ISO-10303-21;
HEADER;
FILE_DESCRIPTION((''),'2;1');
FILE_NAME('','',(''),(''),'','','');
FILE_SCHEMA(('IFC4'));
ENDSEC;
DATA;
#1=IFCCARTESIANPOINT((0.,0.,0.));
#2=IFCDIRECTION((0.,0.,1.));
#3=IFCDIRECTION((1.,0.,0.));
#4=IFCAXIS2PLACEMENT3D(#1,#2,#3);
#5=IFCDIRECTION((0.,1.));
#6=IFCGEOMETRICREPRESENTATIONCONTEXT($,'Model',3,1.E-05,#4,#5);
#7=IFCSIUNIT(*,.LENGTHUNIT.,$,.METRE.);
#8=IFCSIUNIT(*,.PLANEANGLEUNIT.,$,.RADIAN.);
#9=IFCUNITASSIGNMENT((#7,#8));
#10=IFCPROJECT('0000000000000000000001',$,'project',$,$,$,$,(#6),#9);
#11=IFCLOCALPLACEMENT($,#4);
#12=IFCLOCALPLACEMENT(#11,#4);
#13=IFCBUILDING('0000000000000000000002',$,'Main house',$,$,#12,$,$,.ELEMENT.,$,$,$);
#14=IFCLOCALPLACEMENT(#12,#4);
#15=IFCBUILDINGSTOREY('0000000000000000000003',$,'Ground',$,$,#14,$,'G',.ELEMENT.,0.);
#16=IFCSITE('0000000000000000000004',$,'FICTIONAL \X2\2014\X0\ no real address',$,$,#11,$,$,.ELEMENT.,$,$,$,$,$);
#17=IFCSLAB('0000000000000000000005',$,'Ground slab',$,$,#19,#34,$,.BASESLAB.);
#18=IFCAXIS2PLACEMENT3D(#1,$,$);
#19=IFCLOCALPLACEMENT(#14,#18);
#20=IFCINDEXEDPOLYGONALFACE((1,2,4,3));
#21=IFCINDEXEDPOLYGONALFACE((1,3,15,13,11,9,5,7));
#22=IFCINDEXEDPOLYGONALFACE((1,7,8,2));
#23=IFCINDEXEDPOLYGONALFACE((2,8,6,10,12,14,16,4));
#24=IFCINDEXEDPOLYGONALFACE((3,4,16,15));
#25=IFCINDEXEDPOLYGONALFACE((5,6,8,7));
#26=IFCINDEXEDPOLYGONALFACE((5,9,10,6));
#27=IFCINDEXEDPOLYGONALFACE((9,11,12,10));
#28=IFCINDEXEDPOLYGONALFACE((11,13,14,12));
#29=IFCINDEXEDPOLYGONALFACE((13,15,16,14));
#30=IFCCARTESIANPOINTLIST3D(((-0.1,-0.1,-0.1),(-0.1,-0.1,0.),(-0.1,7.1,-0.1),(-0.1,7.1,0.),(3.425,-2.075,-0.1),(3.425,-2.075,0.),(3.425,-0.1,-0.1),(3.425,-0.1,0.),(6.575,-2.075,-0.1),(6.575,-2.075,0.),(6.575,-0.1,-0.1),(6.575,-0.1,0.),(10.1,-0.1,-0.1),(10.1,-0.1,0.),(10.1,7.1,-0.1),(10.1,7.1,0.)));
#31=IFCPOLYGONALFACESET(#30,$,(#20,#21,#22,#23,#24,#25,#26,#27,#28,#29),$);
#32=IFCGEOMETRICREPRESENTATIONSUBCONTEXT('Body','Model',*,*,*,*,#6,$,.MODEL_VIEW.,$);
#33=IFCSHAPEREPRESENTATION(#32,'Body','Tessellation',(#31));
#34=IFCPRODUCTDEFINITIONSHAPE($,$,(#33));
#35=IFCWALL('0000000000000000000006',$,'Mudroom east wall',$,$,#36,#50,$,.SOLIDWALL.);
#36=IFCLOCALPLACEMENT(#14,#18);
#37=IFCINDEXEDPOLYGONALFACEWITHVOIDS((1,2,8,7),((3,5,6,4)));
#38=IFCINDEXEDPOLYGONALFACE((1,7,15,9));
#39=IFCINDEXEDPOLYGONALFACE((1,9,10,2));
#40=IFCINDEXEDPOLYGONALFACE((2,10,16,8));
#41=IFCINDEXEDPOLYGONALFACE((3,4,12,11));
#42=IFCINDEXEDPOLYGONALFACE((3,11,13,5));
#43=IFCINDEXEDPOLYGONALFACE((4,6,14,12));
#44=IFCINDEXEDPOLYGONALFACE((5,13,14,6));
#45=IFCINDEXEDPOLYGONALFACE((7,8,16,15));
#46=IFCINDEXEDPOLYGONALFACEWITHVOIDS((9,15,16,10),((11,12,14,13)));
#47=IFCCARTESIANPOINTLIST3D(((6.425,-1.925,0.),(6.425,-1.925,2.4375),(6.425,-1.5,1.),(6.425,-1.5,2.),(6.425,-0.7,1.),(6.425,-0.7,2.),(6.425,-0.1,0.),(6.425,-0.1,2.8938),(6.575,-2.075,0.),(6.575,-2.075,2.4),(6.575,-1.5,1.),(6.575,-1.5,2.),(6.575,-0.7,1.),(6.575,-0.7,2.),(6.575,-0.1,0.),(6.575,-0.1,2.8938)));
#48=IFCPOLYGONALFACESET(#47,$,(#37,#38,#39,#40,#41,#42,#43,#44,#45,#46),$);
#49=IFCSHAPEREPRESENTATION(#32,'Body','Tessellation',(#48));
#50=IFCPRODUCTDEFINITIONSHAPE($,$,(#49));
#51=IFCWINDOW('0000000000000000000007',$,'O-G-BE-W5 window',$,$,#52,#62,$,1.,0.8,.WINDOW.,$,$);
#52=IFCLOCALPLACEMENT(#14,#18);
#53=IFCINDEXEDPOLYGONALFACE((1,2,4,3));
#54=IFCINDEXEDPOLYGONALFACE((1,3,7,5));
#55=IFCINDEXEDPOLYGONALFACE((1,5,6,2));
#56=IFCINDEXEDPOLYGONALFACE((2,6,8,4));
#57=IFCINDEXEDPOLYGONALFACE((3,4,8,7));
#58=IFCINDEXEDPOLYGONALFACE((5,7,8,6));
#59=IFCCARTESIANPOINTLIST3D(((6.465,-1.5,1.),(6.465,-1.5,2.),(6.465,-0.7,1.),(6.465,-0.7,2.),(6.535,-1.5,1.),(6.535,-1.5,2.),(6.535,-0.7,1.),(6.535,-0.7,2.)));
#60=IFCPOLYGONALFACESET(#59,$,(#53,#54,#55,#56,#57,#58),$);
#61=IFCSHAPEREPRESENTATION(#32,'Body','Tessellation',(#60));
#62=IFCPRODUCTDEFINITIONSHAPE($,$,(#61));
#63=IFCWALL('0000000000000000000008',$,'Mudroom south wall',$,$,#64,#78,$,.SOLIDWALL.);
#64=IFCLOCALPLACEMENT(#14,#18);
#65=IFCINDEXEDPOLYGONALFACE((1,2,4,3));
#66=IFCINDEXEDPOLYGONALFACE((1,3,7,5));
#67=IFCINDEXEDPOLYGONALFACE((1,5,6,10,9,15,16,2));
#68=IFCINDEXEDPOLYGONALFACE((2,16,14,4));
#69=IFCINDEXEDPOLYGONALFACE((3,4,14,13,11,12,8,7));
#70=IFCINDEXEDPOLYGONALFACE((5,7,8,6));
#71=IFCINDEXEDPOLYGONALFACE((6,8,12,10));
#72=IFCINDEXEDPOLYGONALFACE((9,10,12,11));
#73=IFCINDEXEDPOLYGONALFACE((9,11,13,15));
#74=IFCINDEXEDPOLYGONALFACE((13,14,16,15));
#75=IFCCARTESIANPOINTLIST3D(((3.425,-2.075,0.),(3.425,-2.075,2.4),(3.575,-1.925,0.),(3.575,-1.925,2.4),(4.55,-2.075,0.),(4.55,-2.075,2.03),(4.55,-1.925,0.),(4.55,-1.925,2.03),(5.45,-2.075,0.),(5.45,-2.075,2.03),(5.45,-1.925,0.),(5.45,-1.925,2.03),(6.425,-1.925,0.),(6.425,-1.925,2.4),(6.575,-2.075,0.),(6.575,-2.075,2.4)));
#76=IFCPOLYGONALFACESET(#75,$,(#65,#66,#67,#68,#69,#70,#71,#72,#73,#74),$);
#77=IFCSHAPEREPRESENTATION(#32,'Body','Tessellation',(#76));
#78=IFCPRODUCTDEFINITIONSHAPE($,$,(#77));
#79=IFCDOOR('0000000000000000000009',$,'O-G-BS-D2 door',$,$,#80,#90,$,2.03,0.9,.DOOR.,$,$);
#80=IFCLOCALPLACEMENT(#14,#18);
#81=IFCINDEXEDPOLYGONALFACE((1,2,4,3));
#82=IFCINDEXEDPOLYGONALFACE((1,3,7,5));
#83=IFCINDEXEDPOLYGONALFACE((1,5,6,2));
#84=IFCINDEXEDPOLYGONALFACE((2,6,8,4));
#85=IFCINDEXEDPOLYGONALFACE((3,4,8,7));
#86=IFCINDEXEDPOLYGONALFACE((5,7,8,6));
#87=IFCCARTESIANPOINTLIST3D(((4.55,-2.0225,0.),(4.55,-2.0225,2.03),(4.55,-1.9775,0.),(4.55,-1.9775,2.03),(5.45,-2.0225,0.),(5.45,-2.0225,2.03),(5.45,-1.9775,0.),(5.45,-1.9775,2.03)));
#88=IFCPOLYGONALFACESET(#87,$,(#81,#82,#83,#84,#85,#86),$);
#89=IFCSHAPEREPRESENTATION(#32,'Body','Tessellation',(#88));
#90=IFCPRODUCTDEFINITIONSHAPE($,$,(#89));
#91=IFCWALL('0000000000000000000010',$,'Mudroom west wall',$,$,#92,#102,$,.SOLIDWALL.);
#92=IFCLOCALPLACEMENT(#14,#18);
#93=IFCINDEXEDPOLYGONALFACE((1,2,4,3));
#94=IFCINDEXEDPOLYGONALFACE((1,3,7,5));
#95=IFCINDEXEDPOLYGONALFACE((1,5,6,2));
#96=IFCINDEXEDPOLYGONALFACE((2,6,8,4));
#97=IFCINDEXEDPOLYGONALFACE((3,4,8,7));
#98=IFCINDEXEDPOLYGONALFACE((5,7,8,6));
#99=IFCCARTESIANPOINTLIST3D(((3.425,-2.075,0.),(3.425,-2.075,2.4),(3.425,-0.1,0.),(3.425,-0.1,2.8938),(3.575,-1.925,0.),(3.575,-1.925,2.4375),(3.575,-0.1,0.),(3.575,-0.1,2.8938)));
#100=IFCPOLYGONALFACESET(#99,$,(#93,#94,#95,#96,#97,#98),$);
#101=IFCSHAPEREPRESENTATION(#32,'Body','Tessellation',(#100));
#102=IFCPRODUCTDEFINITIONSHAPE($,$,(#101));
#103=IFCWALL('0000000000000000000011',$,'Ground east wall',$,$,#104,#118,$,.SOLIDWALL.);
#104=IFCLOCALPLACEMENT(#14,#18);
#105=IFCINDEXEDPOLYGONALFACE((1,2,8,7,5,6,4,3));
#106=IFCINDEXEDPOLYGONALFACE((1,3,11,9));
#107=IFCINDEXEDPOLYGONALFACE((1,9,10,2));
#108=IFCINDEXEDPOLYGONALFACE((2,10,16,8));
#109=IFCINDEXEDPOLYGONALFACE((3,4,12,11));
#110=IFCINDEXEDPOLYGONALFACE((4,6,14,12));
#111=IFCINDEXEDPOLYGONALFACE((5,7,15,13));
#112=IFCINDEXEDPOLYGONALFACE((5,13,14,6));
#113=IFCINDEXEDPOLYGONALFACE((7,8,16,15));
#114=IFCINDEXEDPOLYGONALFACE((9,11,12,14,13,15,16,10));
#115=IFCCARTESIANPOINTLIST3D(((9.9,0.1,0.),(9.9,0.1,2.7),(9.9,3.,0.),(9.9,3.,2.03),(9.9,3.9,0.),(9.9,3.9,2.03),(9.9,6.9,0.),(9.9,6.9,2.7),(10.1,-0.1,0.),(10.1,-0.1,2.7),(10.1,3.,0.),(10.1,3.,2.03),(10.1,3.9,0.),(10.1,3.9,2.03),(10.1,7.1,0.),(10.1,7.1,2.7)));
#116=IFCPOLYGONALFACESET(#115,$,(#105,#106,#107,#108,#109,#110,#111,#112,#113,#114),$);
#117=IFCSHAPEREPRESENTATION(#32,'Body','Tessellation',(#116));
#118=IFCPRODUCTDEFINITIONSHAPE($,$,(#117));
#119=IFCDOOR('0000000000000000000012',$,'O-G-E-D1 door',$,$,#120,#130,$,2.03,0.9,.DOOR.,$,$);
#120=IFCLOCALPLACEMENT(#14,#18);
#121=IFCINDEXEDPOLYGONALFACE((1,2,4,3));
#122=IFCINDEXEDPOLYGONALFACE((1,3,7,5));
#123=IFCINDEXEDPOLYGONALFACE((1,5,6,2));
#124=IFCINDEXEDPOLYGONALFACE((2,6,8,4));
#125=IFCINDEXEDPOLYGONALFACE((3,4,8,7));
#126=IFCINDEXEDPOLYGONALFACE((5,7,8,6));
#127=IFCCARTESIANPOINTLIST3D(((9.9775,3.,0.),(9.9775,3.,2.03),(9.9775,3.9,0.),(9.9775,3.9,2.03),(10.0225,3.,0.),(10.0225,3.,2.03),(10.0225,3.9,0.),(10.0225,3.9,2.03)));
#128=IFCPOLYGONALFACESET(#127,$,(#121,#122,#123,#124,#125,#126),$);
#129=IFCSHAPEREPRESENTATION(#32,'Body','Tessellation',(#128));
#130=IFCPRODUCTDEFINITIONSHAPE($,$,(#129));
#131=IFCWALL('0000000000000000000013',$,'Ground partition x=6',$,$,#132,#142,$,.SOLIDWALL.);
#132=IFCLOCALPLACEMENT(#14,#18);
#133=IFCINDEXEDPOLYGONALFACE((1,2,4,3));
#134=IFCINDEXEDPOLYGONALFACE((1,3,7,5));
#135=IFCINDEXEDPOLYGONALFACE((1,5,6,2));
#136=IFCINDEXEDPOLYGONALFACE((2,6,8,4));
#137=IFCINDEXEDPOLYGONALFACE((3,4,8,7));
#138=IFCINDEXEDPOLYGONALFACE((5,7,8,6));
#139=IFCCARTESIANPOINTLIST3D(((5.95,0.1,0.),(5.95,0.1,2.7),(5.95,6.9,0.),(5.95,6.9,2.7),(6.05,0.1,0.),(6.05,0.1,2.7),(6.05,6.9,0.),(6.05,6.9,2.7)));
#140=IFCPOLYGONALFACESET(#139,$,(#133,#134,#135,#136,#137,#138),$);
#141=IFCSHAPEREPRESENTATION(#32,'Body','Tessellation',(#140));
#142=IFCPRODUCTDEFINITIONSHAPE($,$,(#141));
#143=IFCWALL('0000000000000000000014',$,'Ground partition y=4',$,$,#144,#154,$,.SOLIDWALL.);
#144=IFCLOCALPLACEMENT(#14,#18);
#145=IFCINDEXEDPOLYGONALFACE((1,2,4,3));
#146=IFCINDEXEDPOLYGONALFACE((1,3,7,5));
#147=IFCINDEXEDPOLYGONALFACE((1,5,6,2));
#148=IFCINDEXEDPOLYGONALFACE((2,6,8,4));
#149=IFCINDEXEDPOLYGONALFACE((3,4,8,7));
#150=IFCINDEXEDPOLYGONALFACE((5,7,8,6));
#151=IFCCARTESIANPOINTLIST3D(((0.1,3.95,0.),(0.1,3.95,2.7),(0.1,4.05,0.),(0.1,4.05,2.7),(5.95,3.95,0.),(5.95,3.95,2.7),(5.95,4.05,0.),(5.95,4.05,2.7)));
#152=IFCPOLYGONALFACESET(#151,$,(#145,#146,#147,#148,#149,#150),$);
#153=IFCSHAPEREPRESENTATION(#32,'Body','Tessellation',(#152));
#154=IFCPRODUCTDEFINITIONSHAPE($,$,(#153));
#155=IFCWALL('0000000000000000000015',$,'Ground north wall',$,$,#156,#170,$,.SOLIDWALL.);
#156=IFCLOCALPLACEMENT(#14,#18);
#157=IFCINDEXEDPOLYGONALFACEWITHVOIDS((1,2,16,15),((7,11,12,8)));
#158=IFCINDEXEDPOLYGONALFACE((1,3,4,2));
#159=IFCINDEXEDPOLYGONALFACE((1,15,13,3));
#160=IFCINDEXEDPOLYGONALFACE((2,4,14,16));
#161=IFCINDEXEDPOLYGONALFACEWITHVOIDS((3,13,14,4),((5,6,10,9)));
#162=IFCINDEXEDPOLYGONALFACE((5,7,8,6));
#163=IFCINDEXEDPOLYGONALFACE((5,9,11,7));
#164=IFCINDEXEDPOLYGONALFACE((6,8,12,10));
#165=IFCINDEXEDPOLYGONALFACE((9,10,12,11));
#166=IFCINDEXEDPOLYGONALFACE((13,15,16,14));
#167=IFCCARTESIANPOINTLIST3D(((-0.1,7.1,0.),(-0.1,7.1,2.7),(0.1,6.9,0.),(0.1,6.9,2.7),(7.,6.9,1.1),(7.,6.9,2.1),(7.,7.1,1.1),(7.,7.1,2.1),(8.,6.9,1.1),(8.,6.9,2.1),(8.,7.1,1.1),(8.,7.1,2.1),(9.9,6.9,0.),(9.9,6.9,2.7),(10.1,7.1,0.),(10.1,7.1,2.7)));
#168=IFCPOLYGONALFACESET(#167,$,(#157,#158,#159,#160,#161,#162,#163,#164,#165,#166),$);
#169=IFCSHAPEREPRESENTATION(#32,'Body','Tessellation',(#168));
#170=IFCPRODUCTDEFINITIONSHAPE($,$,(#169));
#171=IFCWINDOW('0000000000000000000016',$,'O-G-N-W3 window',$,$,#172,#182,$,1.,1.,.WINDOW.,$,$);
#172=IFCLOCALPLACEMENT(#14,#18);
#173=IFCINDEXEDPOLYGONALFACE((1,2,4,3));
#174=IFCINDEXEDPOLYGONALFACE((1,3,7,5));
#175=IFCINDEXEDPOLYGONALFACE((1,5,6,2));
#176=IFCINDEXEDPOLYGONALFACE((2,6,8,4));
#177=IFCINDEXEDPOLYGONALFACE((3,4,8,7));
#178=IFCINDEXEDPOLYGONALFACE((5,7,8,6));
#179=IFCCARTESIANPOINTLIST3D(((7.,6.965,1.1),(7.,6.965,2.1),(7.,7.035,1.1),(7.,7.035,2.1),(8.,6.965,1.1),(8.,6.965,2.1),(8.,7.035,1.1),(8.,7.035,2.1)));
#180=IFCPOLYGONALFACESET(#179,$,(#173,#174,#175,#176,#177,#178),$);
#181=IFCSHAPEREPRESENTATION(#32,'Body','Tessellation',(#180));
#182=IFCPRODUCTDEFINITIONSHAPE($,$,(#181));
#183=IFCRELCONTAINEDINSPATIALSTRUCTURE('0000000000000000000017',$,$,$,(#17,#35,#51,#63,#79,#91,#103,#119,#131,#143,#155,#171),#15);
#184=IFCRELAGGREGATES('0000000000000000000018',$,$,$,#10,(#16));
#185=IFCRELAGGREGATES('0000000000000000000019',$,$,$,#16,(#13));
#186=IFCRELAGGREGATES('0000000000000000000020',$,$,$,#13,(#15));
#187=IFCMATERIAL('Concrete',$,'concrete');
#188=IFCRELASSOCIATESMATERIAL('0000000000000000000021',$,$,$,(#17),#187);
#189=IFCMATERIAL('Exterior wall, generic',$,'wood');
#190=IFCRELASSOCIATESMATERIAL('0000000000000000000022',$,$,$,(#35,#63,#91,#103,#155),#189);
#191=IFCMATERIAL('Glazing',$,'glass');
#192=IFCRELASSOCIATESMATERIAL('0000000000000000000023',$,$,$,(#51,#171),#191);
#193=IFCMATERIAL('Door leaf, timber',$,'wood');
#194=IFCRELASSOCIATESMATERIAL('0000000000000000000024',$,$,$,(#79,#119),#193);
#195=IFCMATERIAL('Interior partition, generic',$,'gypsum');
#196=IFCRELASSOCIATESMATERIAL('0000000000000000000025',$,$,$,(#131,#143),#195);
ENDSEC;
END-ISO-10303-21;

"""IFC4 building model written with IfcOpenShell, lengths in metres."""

from ifc_helpers import new_model, si_unit, direction, frame, origin_with_axes, place, context, subcontext, project, spatial, polyline, outline, extrude, clip, halfspace, material, element, fill, save


model = new_model("IFC4")

# Units and contexts
model_context = context("Model", 3, precision=1e-05, world=origin_with_axes(), true_north=direction((0.0, 1.0)))
body_context = subcontext(model_context, "Body", "Model", "MODEL_VIEW")
ifc_project = project(units=[si_unit("LENGTHUNIT", "METRE"), si_unit("PLANEANGLEUNIT", "RADIAN")], contexts=[model_context])

# Site, building, storey
site_placement = place(None, origin_with_axes())
site = spatial("IfcSite", under=ifc_project, at=site_placement, Name="FICTIONAL — no real address", CompositionType="ELEMENT")
building_placement = place(site_placement, origin_with_axes())
building = spatial("IfcBuilding", under=site, at=building_placement, Name="Main house", CompositionType="ELEMENT")
storey_placement = place(building_placement, origin_with_axes())
storey = spatial("IfcBuildingStorey", under=building, at=storey_placement, Name="Ground", LongName="G", CompositionType="ELEMENT", Elevation=0.0)

# Slab
ifc_material_1 = material(Name="Concrete", Category="concrete")
slab_1_placement = place(storey_placement, origin_with_axes())
element("IfcSlab", 1, at=slab_1_placement, inside=storey, material=ifc_material_1, Name="Ground slab", PredefinedType="BASESLAB", context=body_context, shape_type="SweptSolid", body=[
    extrude(outline(polyline([(-0.1, -0.1), (3.425, -0.1), (3.425, -2.075), (6.575, -2.075), (6.575, -0.1), (10.1, -0.1), (10.1, 7.1), (-0.1, 7.1), (-0.1, -0.1)])), frame((0.0, 0.0, -0.1), z_axis=(0.0, 0.0, 1.0), x_axis=(1.0, 0.0, 0.0)), (0.0, 0.0, 1.0), 0.1),
])

# Wall, opening, window
ifc_material_2 = material(Name="Exterior wall, generic", Category="wood")
wall_1_placement = place(storey_placement, origin_with_axes())
wall_1 = element("IfcWall", 2, at=wall_1_placement, inside=storey, material=ifc_material_2, Name="Mudroom east wall", PredefinedType="SOLIDWALL", context=body_context, shape_type="Clipping", body=[
    clip(extrude(outline(polyline([(6.575, -2.075), (6.575, -0.1), (6.425, -0.1), (6.425, -1.925), (6.575, -2.075)])), origin_with_axes(), (0.0, 0.0, 1.0), 4.0484), halfspace(frame((0.0, 0.0, 2.9188), z_axis=(0.0, -0.242536, 0.970143), x_axis=(1.0, 0.0, 0.0)), False)),
])
opening_1_placement = place(storey_placement, origin_with_axes())
opening_1 = element("IfcOpeningElement", 3, at=opening_1_placement, cuts=wall_1, PredefinedType="OPENING", context=body_context, shape_type="SweptSolid", body=[
    extrude(outline(polyline([(6.58, -1.5), (6.58, -0.7), (6.42, -0.7), (6.42, -1.5), (6.58, -1.5)])), frame((0.0, 0.0, 1.0), z_axis=(0.0, 0.0, 1.0), x_axis=(1.0, 0.0, 0.0)), (0.0, 0.0, 1.0), 1.0),
])
ifc_material_3 = material(Name="Glazing", Category="glass")
window_1_placement = place(storey_placement, origin_with_axes())
window_1 = element("IfcWindow", 4, at=window_1_placement, inside=storey, material=ifc_material_3, Name="O-G-BE-W5 window", OverallHeight=1.0, OverallWidth=0.8, PredefinedType="WINDOW", context=body_context, shape_type="SweptSolid", body=[
    extrude(outline(polyline([(6.535, -1.5), (6.535, -0.7), (6.465, -0.7), (6.465, -1.5), (6.535, -1.5)])), frame((0.0, 0.0, 1.0), z_axis=(0.0, 0.0, 1.0), x_axis=(1.0, 0.0, 0.0)), (0.0, 0.0, 1.0), 1.0),
])
fill(opening_1, window_1)

# Wall, opening, door
wall_2_placement = place(storey_placement, origin_with_axes())
wall_2 = element("IfcWall", 5, at=wall_2_placement, inside=storey, material=ifc_material_2, Name="Mudroom south wall", PredefinedType="SOLIDWALL", context=body_context, shape_type="SweptSolid", body=[
    extrude(outline(polyline([(3.425, -2.075), (6.575, -2.075), (6.425, -1.925), (3.575, -1.925), (3.425, -2.075)])), origin_with_axes(), (0.0, 0.0, 1.0), 2.4),
])
opening_2_placement = place(storey_placement, origin_with_axes())
opening_2 = element("IfcOpeningElement", 6, at=opening_2_placement, cuts=wall_2, PredefinedType="OPENING", context=body_context, shape_type="SweptSolid", body=[
    extrude(outline(polyline([(4.55, -2.08), (5.45, -2.08), (5.45, -1.92), (4.55, -1.92), (4.55, -2.08)])), origin_with_axes(), (0.0, 0.0, 1.0), 2.03),
])
ifc_material_4 = material(Name="Door leaf, timber", Category="wood")
door_1_placement = place(storey_placement, origin_with_axes())
door_1 = element("IfcDoor", 7, at=door_1_placement, inside=storey, material=ifc_material_4, Name="O-G-BS-D2 door", OverallHeight=2.03, OverallWidth=0.9, PredefinedType="DOOR", context=body_context, shape_type="SweptSolid", body=[
    extrude(outline(polyline([(4.55, -2.0225), (5.45, -2.0225), (5.45, -1.9775), (4.55, -1.9775), (4.55, -2.0225)])), origin_with_axes(), (0.0, 0.0, 1.0), 2.03),
])
fill(opening_2, door_1)

# Wall
wall_3_placement = place(storey_placement, origin_with_axes())
element("IfcWall", 8, at=wall_3_placement, inside=storey, material=ifc_material_2, Name="Mudroom west wall", PredefinedType="SOLIDWALL", context=body_context, shape_type="Clipping", body=[
    clip(extrude(outline(polyline([(3.425, -0.1), (3.425, -2.075), (3.575, -1.925), (3.575, -0.1), (3.425, -0.1)])), origin_with_axes(), (0.0, 0.0, 1.0), 4.0484), halfspace(frame((0.0, 0.0, 2.9188), z_axis=(0.0, -0.242536, 0.970143), x_axis=(1.0, 0.0, 0.0)), False)),
])

# Wall, opening, door
wall_4_placement = place(storey_placement, origin_with_axes())
wall_4 = element("IfcWall", 9, at=wall_4_placement, inside=storey, material=ifc_material_2, Name="Ground east wall", PredefinedType="SOLIDWALL", context=body_context, shape_type="SweptSolid", body=[
    extrude(outline(polyline([(10.1, -0.1), (10.1, 7.1), (9.9, 6.9), (9.9, 0.1), (10.1, -0.1)])), origin_with_axes(), (0.0, 0.0, 1.0), 2.7),
])
opening_3_placement = place(storey_placement, origin_with_axes())
opening_3 = element("IfcOpeningElement", 10, at=opening_3_placement, cuts=wall_4, PredefinedType="OPENING", context=body_context, shape_type="SweptSolid", body=[
    extrude(outline(polyline([(10.105, 3.0), (10.105, 3.9), (9.895, 3.9), (9.895, 3.0), (10.105, 3.0)])), origin_with_axes(), (0.0, 0.0, 1.0), 2.03),
])
door_2_placement = place(storey_placement, origin_with_axes())
door_2 = element("IfcDoor", 11, at=door_2_placement, inside=storey, material=ifc_material_4, Name="O-G-E-D1 door", OverallHeight=2.03, OverallWidth=0.9, PredefinedType="DOOR", context=body_context, shape_type="SweptSolid", body=[
    extrude(outline(polyline([(10.0225, 3.0), (10.0225, 3.9), (9.9775, 3.9), (9.9775, 3.0), (10.0225, 3.0)])), origin_with_axes(), (0.0, 0.0, 1.0), 2.03),
])
fill(opening_3, door_2)

# Walls
ifc_material_5 = material(Name="Interior partition, generic", Category="gypsum")
wall_5_placement = place(storey_placement, origin_with_axes())
element("IfcWall", 12, at=wall_5_placement, inside=storey, material=ifc_material_5, Name="Ground partition x=6", PredefinedType="SOLIDWALL", context=body_context, shape_type="SweptSolid", body=[
    extrude(outline(polyline([(6.05, 0.1), (6.05, 6.9), (5.95, 6.9), (5.95, 0.1), (6.05, 0.1)])), origin_with_axes(), (0.0, 0.0, 1.0), 2.7),
])
wall_6_placement = place(storey_placement, origin_with_axes())
element("IfcWall", 13, at=wall_6_placement, inside=storey, material=ifc_material_5, Name="Ground partition y=4", PredefinedType="SOLIDWALL", context=body_context, shape_type="SweptSolid", body=[
    extrude(outline(polyline([(0.1, 3.95), (5.95, 3.95), (5.95, 4.05), (0.1, 4.05), (0.1, 3.95)])), origin_with_axes(), (0.0, 0.0, 1.0), 2.7),
])

# Wall, opening, window
wall_7_placement = place(storey_placement, origin_with_axes())
wall_7 = element("IfcWall", 14, at=wall_7_placement, inside=storey, material=ifc_material_2, Name="Ground north wall", PredefinedType="SOLIDWALL", context=body_context, shape_type="SweptSolid", body=[
    extrude(outline(polyline([(10.1, 7.1), (-0.1, 7.1), (0.1, 6.9), (9.9, 6.9), (10.1, 7.1)])), origin_with_axes(), (0.0, 0.0, 1.0), 2.7),
])
opening_4_placement = place(storey_placement, origin_with_axes())
opening_4 = element("IfcOpeningElement", 15, at=opening_4_placement, cuts=wall_7, PredefinedType="OPENING", context=body_context, shape_type="SweptSolid", body=[
    extrude(outline(polyline([(8.0, 7.105), (7.0, 7.105), (7.0, 6.895), (8.0, 6.895), (8.0, 7.105)])), frame((0.0, 0.0, 1.1), z_axis=(0.0, 0.0, 1.0), x_axis=(1.0, 0.0, 0.0)), (0.0, 0.0, 1.0), 1.0),
])
window_2_placement = place(storey_placement, origin_with_axes())
window_2 = element("IfcWindow", 16, at=window_2_placement, inside=storey, material=ifc_material_3, Name="O-G-N-W3 window", OverallHeight=1.0, OverallWidth=1.0, PredefinedType="WINDOW", context=body_context, shape_type="SweptSolid", body=[
    extrude(outline(polyline([(8.0, 7.035), (7.0, 7.035), (7.0, 6.965), (8.0, 6.965), (8.0, 7.035)])), frame((0.0, 0.0, 1.1), z_axis=(0.0, 0.0, 1.0), x_axis=(1.0, 0.0, 0.0)), (0.0, 0.0, 1.0), 1.0),
])
fill(opening_4, window_2)

save(model, "model.ifc")
